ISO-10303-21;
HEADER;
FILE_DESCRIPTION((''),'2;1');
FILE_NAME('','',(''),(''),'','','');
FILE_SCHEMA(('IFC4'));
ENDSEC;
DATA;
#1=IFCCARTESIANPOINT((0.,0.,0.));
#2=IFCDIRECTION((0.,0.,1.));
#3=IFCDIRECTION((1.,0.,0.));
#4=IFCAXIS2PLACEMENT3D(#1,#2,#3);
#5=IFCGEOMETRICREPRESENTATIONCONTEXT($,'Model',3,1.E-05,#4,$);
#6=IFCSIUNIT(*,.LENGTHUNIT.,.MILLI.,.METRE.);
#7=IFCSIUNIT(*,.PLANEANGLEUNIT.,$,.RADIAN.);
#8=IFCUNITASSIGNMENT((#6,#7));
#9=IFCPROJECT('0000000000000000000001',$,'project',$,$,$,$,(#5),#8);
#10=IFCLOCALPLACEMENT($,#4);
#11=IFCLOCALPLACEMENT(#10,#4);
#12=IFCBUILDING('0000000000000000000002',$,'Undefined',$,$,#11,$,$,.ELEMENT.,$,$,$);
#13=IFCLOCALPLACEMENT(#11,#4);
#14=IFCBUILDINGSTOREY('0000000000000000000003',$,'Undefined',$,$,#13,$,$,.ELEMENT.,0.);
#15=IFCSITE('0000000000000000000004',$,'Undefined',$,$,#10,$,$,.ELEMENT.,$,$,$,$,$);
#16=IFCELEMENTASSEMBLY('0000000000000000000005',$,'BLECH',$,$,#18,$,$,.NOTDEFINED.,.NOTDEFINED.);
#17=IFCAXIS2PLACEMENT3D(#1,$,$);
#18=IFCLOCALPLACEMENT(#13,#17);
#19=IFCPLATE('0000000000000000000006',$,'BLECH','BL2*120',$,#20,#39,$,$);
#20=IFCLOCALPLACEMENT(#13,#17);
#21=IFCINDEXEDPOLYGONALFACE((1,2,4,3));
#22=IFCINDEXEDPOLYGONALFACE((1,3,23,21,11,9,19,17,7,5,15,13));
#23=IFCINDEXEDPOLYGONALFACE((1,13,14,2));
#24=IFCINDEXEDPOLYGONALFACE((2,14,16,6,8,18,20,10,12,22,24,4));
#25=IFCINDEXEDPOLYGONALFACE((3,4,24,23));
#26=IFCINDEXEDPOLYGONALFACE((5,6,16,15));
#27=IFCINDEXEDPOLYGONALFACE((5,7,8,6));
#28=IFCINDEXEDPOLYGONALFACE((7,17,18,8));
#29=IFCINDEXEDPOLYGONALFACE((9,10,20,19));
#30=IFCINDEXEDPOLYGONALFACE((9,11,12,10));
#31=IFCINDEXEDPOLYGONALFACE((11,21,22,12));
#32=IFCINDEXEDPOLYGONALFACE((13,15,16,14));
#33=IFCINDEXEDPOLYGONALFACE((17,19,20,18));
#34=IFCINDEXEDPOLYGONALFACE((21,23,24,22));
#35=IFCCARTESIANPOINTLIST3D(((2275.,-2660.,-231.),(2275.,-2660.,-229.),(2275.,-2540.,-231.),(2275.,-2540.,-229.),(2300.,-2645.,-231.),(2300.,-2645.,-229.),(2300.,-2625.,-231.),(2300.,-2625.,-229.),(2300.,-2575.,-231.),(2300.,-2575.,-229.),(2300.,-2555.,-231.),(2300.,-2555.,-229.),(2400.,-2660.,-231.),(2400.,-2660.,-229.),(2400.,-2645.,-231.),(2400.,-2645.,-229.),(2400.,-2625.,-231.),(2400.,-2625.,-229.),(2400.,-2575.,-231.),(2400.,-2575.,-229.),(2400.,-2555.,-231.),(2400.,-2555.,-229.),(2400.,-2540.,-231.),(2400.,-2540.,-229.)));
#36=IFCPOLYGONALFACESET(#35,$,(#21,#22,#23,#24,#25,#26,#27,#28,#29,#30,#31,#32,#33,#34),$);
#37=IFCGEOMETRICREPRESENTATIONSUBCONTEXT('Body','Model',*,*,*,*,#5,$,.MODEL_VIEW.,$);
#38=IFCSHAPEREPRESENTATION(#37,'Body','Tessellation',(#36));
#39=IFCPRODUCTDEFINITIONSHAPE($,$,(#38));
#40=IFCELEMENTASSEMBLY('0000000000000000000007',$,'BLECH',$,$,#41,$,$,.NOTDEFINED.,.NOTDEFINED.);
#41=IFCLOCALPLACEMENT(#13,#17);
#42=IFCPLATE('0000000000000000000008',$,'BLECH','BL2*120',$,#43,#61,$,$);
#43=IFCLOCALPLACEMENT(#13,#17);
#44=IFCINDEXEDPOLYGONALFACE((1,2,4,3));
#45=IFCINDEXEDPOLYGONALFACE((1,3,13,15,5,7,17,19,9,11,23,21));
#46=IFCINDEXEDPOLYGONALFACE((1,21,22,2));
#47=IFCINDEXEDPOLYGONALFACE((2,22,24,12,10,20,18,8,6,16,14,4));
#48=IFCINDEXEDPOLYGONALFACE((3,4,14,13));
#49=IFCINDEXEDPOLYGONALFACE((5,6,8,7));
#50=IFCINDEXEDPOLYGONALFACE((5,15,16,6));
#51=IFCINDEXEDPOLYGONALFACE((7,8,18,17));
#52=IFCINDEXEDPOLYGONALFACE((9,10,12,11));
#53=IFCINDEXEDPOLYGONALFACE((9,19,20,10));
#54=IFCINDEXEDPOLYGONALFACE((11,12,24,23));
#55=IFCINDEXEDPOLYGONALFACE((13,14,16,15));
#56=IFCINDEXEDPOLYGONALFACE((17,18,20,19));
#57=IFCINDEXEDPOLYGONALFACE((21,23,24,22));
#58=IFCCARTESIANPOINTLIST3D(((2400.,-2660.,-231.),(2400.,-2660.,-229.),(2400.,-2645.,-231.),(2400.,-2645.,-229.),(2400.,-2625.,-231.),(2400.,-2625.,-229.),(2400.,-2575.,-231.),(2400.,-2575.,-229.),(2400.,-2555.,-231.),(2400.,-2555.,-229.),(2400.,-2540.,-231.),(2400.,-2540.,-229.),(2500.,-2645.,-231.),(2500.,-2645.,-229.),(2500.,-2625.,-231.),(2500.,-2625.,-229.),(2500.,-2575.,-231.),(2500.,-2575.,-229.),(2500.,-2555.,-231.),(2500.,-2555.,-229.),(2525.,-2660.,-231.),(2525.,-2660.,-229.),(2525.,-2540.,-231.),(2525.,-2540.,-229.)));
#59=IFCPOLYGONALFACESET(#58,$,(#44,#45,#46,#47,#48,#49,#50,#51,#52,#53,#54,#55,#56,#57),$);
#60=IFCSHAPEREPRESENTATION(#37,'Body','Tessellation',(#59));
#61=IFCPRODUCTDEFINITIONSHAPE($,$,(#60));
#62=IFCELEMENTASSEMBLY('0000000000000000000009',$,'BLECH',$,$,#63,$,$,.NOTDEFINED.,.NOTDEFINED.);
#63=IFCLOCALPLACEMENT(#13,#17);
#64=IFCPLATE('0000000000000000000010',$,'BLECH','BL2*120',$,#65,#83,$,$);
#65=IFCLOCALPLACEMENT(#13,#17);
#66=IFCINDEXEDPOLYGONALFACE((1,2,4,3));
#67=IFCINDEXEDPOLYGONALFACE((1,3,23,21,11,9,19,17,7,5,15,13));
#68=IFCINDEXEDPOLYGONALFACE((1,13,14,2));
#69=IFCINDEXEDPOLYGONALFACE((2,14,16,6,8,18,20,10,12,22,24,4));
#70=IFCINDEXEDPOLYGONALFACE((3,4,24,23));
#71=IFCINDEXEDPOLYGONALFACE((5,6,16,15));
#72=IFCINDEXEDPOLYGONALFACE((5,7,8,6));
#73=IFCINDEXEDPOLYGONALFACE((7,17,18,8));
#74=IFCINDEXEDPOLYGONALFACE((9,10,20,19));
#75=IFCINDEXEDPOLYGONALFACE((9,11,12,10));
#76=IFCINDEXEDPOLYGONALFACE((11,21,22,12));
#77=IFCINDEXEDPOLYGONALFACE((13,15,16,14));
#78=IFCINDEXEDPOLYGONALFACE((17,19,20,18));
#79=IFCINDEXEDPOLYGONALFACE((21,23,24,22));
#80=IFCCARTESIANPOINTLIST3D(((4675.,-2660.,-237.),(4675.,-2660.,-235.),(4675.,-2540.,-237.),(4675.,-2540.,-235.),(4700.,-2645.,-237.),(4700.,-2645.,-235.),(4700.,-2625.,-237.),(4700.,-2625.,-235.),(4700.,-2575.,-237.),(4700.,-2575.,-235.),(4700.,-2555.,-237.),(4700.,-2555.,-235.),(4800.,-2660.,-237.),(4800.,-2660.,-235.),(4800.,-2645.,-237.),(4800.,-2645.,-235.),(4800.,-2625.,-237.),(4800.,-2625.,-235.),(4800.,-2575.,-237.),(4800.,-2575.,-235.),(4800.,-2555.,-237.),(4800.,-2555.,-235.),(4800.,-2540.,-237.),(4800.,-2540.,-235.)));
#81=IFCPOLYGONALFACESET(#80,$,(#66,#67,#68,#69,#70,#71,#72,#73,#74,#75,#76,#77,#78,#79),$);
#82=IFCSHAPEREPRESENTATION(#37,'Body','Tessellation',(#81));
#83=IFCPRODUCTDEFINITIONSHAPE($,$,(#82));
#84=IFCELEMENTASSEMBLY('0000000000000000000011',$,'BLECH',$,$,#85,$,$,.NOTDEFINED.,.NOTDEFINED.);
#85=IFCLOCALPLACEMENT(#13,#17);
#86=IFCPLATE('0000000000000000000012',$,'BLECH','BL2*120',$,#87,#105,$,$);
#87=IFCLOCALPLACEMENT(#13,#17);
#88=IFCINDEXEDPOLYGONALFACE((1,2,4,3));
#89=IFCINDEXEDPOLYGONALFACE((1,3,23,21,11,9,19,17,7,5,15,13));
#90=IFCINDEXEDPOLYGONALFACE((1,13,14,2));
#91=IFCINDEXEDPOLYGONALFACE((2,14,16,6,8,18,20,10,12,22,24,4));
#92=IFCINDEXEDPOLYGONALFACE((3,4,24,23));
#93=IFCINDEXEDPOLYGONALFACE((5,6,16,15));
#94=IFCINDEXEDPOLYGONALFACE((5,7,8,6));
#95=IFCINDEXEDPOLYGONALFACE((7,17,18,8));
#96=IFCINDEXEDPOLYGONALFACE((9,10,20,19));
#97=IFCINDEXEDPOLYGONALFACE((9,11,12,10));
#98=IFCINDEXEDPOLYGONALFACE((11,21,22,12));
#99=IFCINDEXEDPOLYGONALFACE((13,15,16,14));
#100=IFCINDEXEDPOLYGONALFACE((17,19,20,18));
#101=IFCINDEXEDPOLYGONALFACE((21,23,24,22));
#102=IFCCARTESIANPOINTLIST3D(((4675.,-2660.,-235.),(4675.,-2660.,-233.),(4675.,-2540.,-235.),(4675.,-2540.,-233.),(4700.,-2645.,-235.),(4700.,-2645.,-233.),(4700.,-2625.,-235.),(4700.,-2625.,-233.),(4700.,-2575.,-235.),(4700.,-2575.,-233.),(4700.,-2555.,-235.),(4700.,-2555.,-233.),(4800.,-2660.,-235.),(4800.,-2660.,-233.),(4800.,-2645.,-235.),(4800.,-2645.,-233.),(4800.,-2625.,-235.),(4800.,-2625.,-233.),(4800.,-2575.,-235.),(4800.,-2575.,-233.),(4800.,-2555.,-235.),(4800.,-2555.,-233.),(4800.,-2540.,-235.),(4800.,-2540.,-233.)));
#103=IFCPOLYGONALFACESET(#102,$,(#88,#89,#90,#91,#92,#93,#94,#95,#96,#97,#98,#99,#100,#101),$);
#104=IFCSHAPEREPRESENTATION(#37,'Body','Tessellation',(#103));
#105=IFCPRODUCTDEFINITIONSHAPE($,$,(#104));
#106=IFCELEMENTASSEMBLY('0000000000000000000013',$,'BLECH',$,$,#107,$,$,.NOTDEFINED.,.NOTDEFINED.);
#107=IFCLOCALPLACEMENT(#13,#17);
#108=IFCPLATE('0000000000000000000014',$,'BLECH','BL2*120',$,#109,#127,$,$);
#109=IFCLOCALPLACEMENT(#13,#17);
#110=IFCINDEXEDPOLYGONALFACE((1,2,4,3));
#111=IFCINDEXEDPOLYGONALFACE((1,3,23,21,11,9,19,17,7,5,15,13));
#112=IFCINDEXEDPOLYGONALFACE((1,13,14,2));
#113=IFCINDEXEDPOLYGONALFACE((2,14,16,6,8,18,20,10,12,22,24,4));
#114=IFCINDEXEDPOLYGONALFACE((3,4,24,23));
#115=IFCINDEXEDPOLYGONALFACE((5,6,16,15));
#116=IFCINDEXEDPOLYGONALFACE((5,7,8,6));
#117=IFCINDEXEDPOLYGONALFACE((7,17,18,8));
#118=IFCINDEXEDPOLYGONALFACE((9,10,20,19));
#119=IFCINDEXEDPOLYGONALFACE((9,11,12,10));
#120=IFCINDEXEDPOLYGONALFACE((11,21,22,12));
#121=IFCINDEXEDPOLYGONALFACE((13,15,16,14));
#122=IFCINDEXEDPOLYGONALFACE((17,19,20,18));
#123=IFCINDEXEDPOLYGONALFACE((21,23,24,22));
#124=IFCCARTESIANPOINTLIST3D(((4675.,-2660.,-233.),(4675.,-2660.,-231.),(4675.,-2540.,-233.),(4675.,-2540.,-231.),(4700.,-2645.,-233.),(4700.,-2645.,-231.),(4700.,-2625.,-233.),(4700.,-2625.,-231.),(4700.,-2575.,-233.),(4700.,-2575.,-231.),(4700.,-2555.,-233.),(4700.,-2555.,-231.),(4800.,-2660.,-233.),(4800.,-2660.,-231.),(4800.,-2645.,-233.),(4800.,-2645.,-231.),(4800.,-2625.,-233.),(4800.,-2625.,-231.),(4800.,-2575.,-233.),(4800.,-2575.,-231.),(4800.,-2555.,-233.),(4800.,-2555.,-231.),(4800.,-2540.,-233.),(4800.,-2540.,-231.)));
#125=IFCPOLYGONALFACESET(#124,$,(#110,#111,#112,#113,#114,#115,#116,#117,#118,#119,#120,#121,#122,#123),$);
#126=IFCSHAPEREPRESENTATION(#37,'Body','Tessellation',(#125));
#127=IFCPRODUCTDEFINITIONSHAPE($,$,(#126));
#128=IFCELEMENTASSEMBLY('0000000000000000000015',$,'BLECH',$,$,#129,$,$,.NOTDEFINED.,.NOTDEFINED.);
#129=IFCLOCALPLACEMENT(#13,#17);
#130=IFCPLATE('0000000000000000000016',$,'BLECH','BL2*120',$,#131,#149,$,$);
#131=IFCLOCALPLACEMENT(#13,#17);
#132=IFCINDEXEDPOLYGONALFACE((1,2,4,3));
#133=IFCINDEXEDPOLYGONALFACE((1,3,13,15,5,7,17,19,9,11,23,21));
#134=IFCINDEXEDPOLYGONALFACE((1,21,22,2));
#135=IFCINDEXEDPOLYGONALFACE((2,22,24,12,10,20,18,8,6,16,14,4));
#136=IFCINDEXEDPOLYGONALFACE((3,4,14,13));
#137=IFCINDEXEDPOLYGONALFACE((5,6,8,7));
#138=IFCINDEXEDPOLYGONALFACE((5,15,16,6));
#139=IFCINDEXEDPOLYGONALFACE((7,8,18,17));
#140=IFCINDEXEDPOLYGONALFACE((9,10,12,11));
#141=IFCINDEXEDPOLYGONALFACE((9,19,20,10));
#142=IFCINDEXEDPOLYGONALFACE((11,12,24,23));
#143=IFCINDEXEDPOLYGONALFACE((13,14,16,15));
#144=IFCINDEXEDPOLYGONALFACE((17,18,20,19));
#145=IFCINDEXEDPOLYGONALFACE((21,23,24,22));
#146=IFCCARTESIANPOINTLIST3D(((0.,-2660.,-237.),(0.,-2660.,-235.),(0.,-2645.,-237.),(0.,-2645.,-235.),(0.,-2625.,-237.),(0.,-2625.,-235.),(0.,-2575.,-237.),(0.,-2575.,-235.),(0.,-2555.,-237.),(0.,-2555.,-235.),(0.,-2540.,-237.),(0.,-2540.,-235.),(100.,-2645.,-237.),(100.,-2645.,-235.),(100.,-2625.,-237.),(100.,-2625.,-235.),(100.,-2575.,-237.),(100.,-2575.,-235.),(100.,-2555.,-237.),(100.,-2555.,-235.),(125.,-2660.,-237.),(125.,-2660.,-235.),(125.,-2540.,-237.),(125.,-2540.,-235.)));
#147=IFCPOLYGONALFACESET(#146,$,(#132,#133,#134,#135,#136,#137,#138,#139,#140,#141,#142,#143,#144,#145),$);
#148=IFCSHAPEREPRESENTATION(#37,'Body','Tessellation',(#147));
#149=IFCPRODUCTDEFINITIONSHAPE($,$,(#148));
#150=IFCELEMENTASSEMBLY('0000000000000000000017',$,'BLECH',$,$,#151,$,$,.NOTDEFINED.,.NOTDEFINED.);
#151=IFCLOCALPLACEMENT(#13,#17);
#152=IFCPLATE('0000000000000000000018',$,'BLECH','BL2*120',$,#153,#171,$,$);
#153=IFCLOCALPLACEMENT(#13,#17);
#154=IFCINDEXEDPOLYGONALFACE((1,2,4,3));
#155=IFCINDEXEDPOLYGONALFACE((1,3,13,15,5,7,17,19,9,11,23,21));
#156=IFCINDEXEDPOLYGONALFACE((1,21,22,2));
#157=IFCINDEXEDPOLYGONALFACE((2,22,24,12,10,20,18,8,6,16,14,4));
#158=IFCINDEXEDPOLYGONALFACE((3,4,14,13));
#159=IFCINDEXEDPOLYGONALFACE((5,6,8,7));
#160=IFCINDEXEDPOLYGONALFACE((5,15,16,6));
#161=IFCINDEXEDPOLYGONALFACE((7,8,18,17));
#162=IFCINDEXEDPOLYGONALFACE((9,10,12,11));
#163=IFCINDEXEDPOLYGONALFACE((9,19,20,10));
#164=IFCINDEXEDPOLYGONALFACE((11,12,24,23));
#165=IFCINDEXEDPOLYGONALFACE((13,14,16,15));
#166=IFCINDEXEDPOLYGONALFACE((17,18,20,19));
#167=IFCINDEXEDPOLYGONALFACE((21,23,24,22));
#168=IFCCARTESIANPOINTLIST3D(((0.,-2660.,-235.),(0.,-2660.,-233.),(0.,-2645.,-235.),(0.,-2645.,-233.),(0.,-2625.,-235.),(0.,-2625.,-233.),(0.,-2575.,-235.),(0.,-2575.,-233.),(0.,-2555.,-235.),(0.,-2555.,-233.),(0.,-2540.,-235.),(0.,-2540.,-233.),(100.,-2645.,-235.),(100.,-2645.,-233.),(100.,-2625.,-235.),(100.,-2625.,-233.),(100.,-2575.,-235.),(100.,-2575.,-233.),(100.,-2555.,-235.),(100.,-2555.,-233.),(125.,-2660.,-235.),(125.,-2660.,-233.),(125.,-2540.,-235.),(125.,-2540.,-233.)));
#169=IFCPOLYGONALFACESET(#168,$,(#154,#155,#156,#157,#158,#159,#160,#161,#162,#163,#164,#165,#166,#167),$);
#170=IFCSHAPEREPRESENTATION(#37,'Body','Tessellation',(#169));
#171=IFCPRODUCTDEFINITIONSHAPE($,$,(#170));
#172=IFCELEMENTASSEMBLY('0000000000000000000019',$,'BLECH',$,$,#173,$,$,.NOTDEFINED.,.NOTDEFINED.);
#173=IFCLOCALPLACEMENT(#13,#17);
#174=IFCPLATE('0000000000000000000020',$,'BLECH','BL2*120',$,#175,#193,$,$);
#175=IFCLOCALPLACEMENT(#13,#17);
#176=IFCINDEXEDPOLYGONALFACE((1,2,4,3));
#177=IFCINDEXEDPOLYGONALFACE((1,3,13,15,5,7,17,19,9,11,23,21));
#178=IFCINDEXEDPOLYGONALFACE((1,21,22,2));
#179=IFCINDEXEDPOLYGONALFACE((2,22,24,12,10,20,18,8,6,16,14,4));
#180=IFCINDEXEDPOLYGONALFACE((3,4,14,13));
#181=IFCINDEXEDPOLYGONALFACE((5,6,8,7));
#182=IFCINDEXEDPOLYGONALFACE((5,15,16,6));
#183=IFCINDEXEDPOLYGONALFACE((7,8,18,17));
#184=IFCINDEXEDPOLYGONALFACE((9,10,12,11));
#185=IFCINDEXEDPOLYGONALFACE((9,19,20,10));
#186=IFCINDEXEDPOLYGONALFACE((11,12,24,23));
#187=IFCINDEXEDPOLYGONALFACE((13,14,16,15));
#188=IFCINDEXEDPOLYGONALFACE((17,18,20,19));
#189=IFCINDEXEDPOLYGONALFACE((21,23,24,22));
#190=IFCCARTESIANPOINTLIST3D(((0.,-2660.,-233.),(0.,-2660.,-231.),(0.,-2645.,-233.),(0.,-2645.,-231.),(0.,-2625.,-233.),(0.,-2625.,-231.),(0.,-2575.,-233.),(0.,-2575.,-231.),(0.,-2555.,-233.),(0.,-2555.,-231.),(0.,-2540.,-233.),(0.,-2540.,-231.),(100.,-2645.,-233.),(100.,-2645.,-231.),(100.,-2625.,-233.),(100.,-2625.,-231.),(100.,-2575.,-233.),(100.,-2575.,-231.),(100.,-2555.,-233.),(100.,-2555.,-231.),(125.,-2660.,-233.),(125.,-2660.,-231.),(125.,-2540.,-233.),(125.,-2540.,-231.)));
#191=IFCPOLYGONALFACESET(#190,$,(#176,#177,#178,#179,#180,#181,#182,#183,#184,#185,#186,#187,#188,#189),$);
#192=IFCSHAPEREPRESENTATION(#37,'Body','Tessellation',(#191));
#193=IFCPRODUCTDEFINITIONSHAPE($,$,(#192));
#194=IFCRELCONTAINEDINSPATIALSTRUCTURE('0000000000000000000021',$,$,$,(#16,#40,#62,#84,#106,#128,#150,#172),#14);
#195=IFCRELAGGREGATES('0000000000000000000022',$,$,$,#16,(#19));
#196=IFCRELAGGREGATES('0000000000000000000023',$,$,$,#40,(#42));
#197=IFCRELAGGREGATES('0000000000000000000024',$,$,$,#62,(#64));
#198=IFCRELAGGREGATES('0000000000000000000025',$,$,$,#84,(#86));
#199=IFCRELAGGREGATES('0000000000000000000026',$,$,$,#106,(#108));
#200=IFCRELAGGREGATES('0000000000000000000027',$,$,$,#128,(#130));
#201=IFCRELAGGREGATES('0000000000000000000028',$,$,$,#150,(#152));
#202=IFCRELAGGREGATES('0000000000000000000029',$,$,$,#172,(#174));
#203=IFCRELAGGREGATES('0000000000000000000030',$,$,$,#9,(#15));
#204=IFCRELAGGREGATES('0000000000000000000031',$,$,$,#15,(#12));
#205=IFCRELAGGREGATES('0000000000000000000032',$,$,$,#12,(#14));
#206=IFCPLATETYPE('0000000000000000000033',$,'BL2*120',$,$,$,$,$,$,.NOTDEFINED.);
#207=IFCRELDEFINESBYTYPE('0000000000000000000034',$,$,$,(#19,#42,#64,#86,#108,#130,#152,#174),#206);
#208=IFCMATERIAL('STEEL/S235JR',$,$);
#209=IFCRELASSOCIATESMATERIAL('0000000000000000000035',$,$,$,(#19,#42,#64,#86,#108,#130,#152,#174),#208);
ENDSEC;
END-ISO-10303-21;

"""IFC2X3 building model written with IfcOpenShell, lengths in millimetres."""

from ifc_helpers import new_model, si_unit, frame, origin_with_axes, place, context, subcontext, project, spatial, polyline, outline, extrude, material, type_object, element, aggregate, save


model = new_model("IFC2X3")

# Units and contexts
model_context = context("Model", 3, precision=1e-05, world=origin_with_axes())
body_context = subcontext(model_context, "Body", "Model", "MODEL_VIEW")
ifc_project = project(units=[si_unit("LENGTHUNIT", "METRE", prefix="MILLI"), si_unit("PLANEANGLEUNIT", "RADIAN")], contexts=[model_context])

# Site, building, storey
site_placement = place(None, origin_with_axes())
site = spatial("IfcSite", under=ifc_project, at=site_placement, Name="Undefined", CompositionType="ELEMENT")
building_placement = place(site_placement, origin_with_axes())
building = spatial("IfcBuilding", under=site, at=building_placement, Name="Undefined", CompositionType="ELEMENT")
storey_placement = place(building_placement, origin_with_axes())
storey = spatial("IfcBuildingStorey", under=building, at=storey_placement, Name="Undefined", CompositionType="ELEMENT", Elevation=0.0)

# Shared definitions
ifc_material = material(Name="STEEL/S235JR")

# Element assemblies, plates
plate_type_1 = type_object("IfcPlateType", Name="BL2*120", PredefinedType="NOTDEFINED")
assembly_1_placement = place(storey_placement, origin_with_axes())
assembly_1 = element("IfcElementAssembly", 1, at=assembly_1_placement, inside=storey, Name="BLECH", AssemblyPlace="NOTDEFINED", PredefinedType="NOTDEFINED")
plate_1_placement = place(assembly_1_placement, frame((2275.0, -2540.0, -230.0), z_axis=(0.0, 0.0, -1.0), x_axis=(1.0, 0.0, 0.0)))
plate_1 = element("IfcPlate", 2, at=plate_1_placement, type_object=plate_type_1, material=ifc_material, Name="BLECH", Description="BL2*120", context=body_context, shape_type="SweptSolid", body=[
    extrude(outline(polyline([(0.0, 0.0), (125.0, 0.0), (125.0, 15.0), (25.0, 15.0), (25.0, 35.0), (125.0, 35.0), (125.0, 85.0), (25.0, 85.0), (25.0, 105.0), (125.0, 105.0), (125.0, 120.0), (0.0, 120.0), (0.0, 0.0)])), frame((0.0, 0.0, -1.0), z_axis=(0.0, 0.0, 1.0), x_axis=(1.0, 0.0, 0.0)), (0.0, 0.0, 1.0), 2.0),
])
aggregate(assembly_1, [plate_1])
assembly_2_placement = place(storey_placement, origin_with_axes())
assembly_2 = element("IfcElementAssembly", 3, at=assembly_2_placement, inside=storey, Name="BLECH", AssemblyPlace="NOTDEFINED", PredefinedType="NOTDEFINED")
plate_2_placement = place(assembly_2_placement, frame((2525.0, -2540.0, -230.0), z_axis=(0.0, 0.0, 1.0), x_axis=(-1.0, 0.0, 0.0)))
plate_2 = element("IfcPlate", 4, at=plate_2_placement, type_object=plate_type_1, material=ifc_material, Name="BLECH", Description="BL2*120", context=body_context, shape_type="SweptSolid", body=[
    extrude(outline(polyline([(0.0, 0.0), (125.0, 0.0), (125.0, 15.0), (25.0, 15.0), (25.0, 35.0), (125.0, 35.0), (125.0, 85.0), (25.0, 85.0), (25.0, 105.0), (125.0, 105.0), (125.0, 120.0), (0.0, 120.0), (0.0, 0.0)])), frame((0.0, 0.0, -1.0), z_axis=(0.0, 0.0, 1.0), x_axis=(1.0, 0.0, 0.0)), (0.0, 0.0, 1.0), 2.0),
])
aggregate(assembly_2, [plate_2])
assembly_3_placement = place(storey_placement, origin_with_axes())
assembly_3 = element("IfcElementAssembly", 5, at=assembly_3_placement, inside=storey, Name="BLECH", AssemblyPlace="NOTDEFINED", PredefinedType="NOTDEFINED")
plate_3_placement = place(assembly_3_placement, frame((4675.0, -2540.0, -236.0), z_axis=(0.0, 0.0, -1.0), x_axis=(1.0, 0.0, 0.0)))
plate_3 = element("IfcPlate", 6, at=plate_3_placement, type_object=plate_type_1, material=ifc_material, Name="BLECH", Description="BL2*120", context=body_context, shape_type="SweptSolid", body=[
    extrude(outline(polyline([(0.0, 0.0), (125.0, 0.0), (125.0, 15.0), (25.0, 15.0), (25.0, 35.0), (125.0, 35.0), (125.0, 85.0), (25.0, 85.0), (25.0, 105.0), (125.0, 105.0), (125.0, 120.0), (0.0, 120.0), (0.0, 0.0)])), frame((0.0, 0.0, -1.0), z_axis=(0.0, 0.0, 1.0), x_axis=(1.0, 0.0, 0.0)), (0.0, 0.0, 1.0), 2.0),
])
aggregate(assembly_3, [plate_3])
assembly_4_placement = place(storey_placement, origin_with_axes())
assembly_4 = element("IfcElementAssembly", 7, at=assembly_4_placement, inside=storey, Name="BLECH", AssemblyPlace="NOTDEFINED", PredefinedType="NOTDEFINED")
plate_4_placement = place(assembly_4_placement, frame((4675.0, -2540.0, -234.0), z_axis=(0.0, 0.0, -1.0), x_axis=(1.0, 0.0, 0.0)))
plate_4 = element("IfcPlate", 8, at=plate_4_placement, type_object=plate_type_1, material=ifc_material, Name="BLECH", Description="BL2*120", context=body_context, shape_type="SweptSolid", body=[
    extrude(outline(polyline([(0.0, 0.0), (125.0, 0.0), (125.0, 15.0), (25.0, 15.0), (25.0, 35.0), (125.0, 35.0), (125.0, 85.0), (25.0, 85.0), (25.0, 105.0), (125.0, 105.0), (125.0, 120.0), (0.0, 120.0), (0.0, 0.0)])), frame((0.0, 0.0, -1.0), z_axis=(0.0, 0.0, 1.0), x_axis=(1.0, 0.0, 0.0)), (0.0, 0.0, 1.0), 2.0),
])
aggregate(assembly_4, [plate_4])
assembly_5_placement = place(storey_placement, origin_with_axes())
assembly_5 = element("IfcElementAssembly", 9, at=assembly_5_placement, inside=storey, Name="BLECH", AssemblyPlace="NOTDEFINED", PredefinedType="NOTDEFINED")
plate_5_placement = place(assembly_5_placement, frame((4675.0, -2540.0, -232.0), z_axis=(0.0, 0.0, -1.0), x_axis=(1.0, 0.0, 0.0)))
plate_5 = element("IfcPlate", 10, at=plate_5_placement, type_object=plate_type_1, material=ifc_material, Name="BLECH", Description="BL2*120", context=body_context, shape_type="SweptSolid", body=[
    extrude(outline(polyline([(0.0, 0.0), (125.0, 0.0), (125.0, 15.0), (25.0, 15.0), (25.0, 35.0), (125.0, 35.0), (125.0, 85.0), (25.0, 85.0), (25.0, 105.0), (125.0, 105.0), (125.0, 120.0), (0.0, 120.0), (0.0, 0.0)])), frame((0.0, 0.0, -1.0), z_axis=(0.0, 0.0, 1.0), x_axis=(1.0, 0.0, 0.0)), (0.0, 0.0, 1.0), 2.0),
])
aggregate(assembly_5, [plate_5])
assembly_6_placement = place(storey_placement, origin_with_axes())
assembly_6 = element("IfcElementAssembly", 11, at=assembly_6_placement, inside=storey, Name="BLECH", AssemblyPlace="NOTDEFINED", PredefinedType="NOTDEFINED")
plate_6_placement = place(assembly_6_placement, frame((125.0, -2540.0, -236.0), z_axis=(0.0, 0.0, 1.0), x_axis=(-1.0, 0.0, 0.0)))
plate_6 = element("IfcPlate", 12, at=plate_6_placement, type_object=plate_type_1, material=ifc_material, Name="BLECH", Description="BL2*120", context=body_context, shape_type="SweptSolid", body=[
    extrude(outline(polyline([(0.0, 0.0), (125.0, 0.0), (125.0, 15.0), (25.0, 15.0), (25.0, 35.0), (125.0, 35.0), (125.0, 85.0), (25.0, 85.0), (25.0, 105.0), (125.0, 105.0), (125.0, 120.0), (0.0, 120.0), (0.0, 0.0)])), frame((0.0, 0.0, -1.0), z_axis=(0.0, 0.0, 1.0), x_axis=(1.0, 0.0, 0.0)), (0.0, 0.0, 1.0), 2.0),
])
aggregate(assembly_6, [plate_6])
assembly_7_placement = place(storey_placement, origin_with_axes())
assembly_7 = element("IfcElementAssembly", 13, at=assembly_7_placement, inside=storey, Name="BLECH", AssemblyPlace="NOTDEFINED", PredefinedType="NOTDEFINED")
plate_7_placement = place(assembly_7_placement, frame((125.0, -2540.0, -234.0), z_axis=(0.0, 0.0, 1.0), x_axis=(-1.0, 0.0, 0.0)))
plate_7 = element("IfcPlate", 14, at=plate_7_placement, type_object=plate_type_1, material=ifc_material, Name="BLECH", Description="BL2*120", context=body_context, shape_type="SweptSolid", body=[
    extrude(outline(polyline([(0.0, 0.0), (125.0, 0.0), (125.0, 15.0), (25.0, 15.0), (25.0, 35.0), (125.0, 35.0), (125.0, 85.0), (25.0, 85.0), (25.0, 105.0), (125.0, 105.0), (125.0, 120.0), (0.0, 120.0), (0.0, 0.0)])), frame((0.0, 0.0, -1.0), z_axis=(0.0, 0.0, 1.0), x_axis=(1.0, 0.0, 0.0)), (0.0, 0.0, 1.0), 2.0),
])
aggregate(assembly_7, [plate_7])
assembly_8_placement = place(storey_placement, origin_with_axes())
assembly_8 = element("IfcElementAssembly", 15, at=assembly_8_placement, inside=storey, Name="BLECH", AssemblyPlace="NOTDEFINED", PredefinedType="NOTDEFINED")
plate_8_placement = place(assembly_8_placement, frame((125.0, -2540.0, -232.0), z_axis=(0.0, 0.0, 1.0), x_axis=(-1.0, 0.0, 0.0)))
plate_8 = element("IfcPlate", 16, at=plate_8_placement, type_object=plate_type_1, material=ifc_material, Name="BLECH", Description="BL2*120", context=body_context, shape_type="SweptSolid", body=[
    extrude(outline(polyline([(0.0, 0.0), (125.0, 0.0), (125.0, 15.0), (25.0, 15.0), (25.0, 35.0), (125.0, 35.0), (125.0, 85.0), (25.0, 85.0), (25.0, 105.0), (125.0, 105.0), (125.0, 120.0), (0.0, 120.0), (0.0, 0.0)])), frame((0.0, 0.0, -1.0), z_axis=(0.0, 0.0, 1.0), x_axis=(1.0, 0.0, 0.0)), (0.0, 0.0, 1.0), 2.0),
])
aggregate(assembly_8, [plate_8])

save(model, "model.ifc")
